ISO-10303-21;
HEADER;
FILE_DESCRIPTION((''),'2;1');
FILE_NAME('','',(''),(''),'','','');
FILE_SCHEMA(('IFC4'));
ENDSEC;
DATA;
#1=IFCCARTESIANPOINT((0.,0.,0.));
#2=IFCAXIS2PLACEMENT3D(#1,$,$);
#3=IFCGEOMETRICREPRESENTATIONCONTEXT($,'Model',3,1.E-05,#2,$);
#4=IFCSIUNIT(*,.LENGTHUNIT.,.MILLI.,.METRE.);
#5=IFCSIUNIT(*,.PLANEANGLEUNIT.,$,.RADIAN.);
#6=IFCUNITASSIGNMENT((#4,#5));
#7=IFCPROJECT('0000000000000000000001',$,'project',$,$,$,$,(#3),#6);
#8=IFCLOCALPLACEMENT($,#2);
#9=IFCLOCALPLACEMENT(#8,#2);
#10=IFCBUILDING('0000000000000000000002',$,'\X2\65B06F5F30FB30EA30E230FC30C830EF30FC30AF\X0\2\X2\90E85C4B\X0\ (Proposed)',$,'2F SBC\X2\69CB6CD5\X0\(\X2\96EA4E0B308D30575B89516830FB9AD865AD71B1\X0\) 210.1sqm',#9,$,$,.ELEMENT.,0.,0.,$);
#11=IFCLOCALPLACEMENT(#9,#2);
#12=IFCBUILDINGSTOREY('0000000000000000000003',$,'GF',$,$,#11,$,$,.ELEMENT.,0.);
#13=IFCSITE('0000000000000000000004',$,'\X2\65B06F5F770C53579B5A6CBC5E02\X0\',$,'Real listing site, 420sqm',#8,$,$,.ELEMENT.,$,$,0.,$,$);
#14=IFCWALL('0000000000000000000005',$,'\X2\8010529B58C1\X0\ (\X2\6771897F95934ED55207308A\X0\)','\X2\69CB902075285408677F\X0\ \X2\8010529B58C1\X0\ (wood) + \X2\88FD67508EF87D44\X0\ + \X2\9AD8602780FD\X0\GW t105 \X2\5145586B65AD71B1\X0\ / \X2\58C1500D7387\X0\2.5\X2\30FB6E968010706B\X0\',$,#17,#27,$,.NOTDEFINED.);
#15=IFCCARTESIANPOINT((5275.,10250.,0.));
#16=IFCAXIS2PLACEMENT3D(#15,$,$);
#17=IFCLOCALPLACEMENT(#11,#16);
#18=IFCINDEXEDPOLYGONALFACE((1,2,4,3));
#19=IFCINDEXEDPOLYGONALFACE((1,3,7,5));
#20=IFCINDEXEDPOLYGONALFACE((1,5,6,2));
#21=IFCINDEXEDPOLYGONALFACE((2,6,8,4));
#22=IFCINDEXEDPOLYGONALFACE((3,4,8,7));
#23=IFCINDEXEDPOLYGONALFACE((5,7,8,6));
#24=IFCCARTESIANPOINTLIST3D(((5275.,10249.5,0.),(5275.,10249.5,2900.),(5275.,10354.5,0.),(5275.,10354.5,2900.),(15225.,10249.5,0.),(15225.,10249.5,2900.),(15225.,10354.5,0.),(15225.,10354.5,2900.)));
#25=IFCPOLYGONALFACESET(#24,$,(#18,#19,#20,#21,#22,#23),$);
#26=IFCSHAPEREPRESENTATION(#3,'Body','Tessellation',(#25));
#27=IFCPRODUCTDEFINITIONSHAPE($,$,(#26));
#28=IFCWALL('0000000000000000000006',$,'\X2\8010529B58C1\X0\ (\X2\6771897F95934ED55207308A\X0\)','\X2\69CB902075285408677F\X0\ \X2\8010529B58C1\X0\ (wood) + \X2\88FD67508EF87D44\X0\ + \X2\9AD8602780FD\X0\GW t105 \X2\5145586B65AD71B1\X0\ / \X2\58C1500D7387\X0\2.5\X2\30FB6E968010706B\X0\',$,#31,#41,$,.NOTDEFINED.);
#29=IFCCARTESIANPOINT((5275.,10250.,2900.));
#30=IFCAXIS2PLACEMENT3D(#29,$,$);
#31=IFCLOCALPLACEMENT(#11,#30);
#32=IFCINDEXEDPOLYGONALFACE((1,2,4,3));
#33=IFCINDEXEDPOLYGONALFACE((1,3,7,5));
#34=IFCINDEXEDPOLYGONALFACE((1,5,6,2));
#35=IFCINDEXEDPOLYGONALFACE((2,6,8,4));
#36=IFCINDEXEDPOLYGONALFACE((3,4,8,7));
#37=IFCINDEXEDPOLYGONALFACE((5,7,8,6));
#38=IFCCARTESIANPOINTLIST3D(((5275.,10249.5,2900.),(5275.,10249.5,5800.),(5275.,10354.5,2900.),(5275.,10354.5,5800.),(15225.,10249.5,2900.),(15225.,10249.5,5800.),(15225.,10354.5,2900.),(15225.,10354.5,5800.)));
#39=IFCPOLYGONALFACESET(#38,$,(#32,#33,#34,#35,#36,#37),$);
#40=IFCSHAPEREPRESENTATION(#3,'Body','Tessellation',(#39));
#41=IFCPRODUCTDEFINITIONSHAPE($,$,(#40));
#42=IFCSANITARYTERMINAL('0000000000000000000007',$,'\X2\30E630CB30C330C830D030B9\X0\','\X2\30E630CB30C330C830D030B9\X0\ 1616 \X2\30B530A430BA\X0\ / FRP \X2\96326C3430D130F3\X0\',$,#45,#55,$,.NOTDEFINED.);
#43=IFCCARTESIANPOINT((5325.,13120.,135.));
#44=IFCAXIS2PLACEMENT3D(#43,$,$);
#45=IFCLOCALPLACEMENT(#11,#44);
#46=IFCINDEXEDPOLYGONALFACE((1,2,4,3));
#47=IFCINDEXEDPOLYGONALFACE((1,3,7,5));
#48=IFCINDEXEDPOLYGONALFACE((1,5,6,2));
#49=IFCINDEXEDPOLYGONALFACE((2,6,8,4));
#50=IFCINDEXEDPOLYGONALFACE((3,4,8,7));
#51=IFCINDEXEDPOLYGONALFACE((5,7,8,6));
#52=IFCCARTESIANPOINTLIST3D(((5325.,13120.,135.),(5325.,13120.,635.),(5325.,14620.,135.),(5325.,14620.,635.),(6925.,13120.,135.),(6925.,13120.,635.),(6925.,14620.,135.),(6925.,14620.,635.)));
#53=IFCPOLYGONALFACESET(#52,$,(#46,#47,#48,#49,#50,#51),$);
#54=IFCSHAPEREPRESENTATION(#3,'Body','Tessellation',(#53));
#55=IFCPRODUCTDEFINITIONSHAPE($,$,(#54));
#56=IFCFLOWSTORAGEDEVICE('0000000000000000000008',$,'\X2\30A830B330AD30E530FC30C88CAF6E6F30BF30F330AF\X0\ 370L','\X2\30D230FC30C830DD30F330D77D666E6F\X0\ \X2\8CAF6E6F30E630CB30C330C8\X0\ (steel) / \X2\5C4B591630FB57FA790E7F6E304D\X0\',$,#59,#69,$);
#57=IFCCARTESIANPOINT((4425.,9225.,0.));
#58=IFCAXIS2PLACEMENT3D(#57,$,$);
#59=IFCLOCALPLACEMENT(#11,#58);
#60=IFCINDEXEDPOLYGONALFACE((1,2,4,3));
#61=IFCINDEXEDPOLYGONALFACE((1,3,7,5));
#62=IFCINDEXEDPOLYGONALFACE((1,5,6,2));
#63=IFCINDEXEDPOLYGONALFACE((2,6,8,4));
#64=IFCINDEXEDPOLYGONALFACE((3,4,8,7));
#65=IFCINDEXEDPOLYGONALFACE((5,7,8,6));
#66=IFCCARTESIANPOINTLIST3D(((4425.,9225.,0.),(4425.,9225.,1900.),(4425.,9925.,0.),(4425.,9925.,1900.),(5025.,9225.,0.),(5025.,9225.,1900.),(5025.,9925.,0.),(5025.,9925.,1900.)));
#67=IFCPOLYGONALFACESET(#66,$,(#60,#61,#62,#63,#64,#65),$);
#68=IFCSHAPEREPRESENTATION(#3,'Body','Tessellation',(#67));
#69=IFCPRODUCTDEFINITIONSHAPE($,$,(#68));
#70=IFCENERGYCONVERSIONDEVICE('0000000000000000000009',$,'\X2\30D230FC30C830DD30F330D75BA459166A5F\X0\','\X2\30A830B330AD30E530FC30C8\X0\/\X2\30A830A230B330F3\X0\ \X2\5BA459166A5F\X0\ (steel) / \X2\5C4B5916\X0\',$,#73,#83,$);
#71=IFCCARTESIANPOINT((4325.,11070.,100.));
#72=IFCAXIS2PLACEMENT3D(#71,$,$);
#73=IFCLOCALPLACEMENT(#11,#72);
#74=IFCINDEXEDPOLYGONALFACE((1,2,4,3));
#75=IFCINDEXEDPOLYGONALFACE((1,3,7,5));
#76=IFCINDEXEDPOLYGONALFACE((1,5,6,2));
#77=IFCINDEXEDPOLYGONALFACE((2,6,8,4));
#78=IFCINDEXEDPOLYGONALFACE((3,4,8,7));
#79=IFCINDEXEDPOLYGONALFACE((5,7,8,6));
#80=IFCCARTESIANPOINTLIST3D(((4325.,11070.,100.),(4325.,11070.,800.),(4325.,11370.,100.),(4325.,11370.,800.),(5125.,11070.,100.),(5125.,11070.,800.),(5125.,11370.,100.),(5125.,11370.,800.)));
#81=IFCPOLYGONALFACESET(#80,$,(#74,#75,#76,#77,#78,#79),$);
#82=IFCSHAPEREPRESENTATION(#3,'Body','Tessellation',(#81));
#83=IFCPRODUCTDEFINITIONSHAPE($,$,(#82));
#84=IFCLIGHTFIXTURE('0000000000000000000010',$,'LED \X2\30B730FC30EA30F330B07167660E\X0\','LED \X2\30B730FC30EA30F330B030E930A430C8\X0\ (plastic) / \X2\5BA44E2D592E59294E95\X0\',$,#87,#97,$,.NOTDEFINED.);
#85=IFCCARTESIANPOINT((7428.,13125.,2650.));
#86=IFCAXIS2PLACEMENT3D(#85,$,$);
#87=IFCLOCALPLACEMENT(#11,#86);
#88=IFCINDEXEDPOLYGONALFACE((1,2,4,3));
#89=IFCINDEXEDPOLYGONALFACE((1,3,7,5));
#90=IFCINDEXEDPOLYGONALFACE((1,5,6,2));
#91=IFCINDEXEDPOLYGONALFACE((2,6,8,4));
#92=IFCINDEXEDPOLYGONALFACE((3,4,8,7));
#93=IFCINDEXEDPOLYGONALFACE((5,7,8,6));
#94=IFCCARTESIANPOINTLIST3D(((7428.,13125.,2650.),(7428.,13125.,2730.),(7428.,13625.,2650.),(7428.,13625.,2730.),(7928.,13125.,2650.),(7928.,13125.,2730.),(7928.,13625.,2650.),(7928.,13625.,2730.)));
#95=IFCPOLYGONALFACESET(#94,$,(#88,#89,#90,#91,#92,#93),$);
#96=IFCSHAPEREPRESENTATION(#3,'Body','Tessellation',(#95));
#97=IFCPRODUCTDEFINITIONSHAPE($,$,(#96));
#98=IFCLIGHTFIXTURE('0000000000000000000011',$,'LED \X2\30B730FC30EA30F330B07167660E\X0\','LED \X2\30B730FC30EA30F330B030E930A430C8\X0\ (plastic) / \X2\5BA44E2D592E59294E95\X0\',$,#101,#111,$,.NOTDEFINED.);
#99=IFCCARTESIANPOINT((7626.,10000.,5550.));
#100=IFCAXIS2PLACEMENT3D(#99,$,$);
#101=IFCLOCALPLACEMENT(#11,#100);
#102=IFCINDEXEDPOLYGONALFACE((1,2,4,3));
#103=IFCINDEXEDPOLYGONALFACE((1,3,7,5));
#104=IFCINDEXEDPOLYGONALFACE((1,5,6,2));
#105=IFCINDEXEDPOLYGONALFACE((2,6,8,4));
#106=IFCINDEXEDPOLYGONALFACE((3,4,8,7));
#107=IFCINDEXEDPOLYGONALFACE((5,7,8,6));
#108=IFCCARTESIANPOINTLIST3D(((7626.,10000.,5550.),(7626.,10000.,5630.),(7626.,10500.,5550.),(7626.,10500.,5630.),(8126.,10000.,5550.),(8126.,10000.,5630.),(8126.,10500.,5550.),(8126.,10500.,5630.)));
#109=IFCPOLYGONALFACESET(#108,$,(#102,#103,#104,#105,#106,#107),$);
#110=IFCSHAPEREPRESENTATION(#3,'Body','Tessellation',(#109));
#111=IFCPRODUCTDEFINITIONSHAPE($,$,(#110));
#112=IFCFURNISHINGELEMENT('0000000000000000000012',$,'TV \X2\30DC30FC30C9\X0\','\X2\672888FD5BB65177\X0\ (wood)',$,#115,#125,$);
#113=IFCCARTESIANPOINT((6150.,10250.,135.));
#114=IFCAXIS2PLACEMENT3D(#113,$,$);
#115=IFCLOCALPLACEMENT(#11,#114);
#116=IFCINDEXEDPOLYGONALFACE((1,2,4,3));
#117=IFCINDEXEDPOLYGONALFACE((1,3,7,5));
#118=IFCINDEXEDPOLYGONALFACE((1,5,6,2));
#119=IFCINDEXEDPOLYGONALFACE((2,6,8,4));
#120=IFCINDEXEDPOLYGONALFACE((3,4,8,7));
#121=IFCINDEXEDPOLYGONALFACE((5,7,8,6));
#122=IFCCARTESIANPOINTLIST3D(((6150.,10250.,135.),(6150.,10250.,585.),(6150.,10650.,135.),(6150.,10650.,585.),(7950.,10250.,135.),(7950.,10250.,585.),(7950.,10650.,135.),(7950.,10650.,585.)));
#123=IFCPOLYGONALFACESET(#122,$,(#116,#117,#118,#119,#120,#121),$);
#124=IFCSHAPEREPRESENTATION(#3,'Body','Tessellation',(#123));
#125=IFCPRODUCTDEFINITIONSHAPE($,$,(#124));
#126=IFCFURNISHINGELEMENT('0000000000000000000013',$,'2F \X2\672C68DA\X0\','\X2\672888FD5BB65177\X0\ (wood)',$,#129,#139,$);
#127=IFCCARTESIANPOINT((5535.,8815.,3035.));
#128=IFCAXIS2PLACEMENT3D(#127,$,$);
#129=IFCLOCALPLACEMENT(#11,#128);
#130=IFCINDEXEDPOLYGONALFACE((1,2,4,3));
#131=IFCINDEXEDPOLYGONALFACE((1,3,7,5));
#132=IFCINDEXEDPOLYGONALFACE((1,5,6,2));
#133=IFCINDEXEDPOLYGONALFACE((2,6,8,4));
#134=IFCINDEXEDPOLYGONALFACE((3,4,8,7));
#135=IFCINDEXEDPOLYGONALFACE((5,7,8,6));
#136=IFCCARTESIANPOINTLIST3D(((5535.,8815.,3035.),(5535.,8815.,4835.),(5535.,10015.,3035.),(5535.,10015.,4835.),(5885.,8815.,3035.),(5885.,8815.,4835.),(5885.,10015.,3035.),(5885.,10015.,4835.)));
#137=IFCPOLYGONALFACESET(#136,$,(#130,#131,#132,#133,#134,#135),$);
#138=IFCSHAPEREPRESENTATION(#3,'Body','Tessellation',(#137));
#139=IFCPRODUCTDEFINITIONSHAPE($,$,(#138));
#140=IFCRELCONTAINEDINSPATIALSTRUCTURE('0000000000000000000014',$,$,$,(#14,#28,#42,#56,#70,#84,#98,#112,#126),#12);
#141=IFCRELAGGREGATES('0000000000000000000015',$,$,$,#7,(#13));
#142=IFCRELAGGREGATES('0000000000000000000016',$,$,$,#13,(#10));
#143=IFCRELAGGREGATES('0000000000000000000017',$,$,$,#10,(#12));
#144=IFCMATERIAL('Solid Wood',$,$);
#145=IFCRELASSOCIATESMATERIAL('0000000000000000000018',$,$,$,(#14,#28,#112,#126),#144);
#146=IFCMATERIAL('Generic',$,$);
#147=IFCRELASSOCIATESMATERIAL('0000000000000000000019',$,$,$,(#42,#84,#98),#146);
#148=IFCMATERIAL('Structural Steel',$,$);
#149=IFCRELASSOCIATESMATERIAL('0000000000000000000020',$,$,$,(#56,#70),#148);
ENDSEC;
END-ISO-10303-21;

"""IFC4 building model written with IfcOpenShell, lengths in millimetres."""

from ifc_helpers import new_model, si_unit, frame, frame_2d, origin, place, context, project, spatial, rectangle, extrude, material, element, save


model = new_model("IFC4")

# Units and contexts
model_context = context("Model", 3, precision=1e-05, world=origin())
ifc_project = project(units=[si_unit("LENGTHUNIT", "METRE", prefix="MILLI"), si_unit("PLANEANGLEUNIT", "RADIAN")], contexts=[model_context])

# Site, building, storey
site_placement = place(None, origin())
site = spatial("IfcSite", under=ifc_project, at=site_placement, Name="新潟県南魚沼市", ObjectType="Real listing site, 420sqm", CompositionType="ELEMENT", RefElevation=0.0)
building_placement = place(site_placement, origin())
building = spatial("IfcBuilding", under=site, at=building_placement, Name="新潟・リモートワーク2部屋 (Proposed)", ObjectType="2F SBC構法(雪下ろし安全・高断熱) 210.1sqm", CompositionType="ELEMENT", ElevationOfRefHeight=0.0, ElevationOfTerrain=0.0)
storey_placement = place(building_placement, origin())
storey = spatial("IfcBuildingStorey", under=building, at=storey_placement, Name="GF", CompositionType="ELEMENT", Elevation=0.0)

# Shared definitions
ifc_material_1 = material(Name="Solid Wood")

# Wall
wall_1_placement = place(storey_placement, frame((5275.0, 10250.0, 0.0)))
element("IfcWall", 1, at=wall_1_placement, inside=storey, material=ifc_material_1, Name="耐力壁 (東西間仕切り)", Description="構造用合板 耐力壁 (wood) + 製材軸組 + 高性能GW t105 充填断熱 / 壁倍率2.5・準耐火", PredefinedType="NOTDEFINED", context=model_context, shape_type="SweptSolid", body=[
    extrude(rectangle(XDim=9950.0, YDim=105.0, at=frame_2d((4975.0, 52.0))), frame((5275.0, 10250.0, 0.0)), (0.0, 0.0, 1.0), 2900.0),
])

# Wall
wall_2_placement = place(storey_placement, frame((5275.0, 10250.0, 2900.0)))
element("IfcWall", 2, at=wall_2_placement, inside=storey, material=ifc_material_1, Name="耐力壁 (東西間仕切り)", Description="構造用合板 耐力壁 (wood) + 製材軸組 + 高性能GW t105 充填断熱 / 壁倍率2.5・準耐火", PredefinedType="NOTDEFINED", context=model_context, shape_type="SweptSolid", body=[
    extrude(rectangle(XDim=9950.0, YDim=105.0, at=frame_2d((4975.0, 52.0))), frame((5275.0, 10250.0, 2900.0)), (0.0, 0.0, 1.0), 2900.0),
])

# Sanitary terminal
ifc_material_2 = material(Name="Generic")
sanitary_terminal_placement = place(storey_placement, frame((5325.0, 13120.0, 135.0)))
element("IfcSanitaryTerminal", 3, at=sanitary_terminal_placement, inside=storey, material=ifc_material_2, Name="ユニットバス", Description="ユニットバス 1616 サイズ / FRP 防水パン", PredefinedType="NOTDEFINED", context=model_context, shape_type="SweptSolid", body=[
    extrude(rectangle(XDim=1600.0, YDim=1500.0, at=frame_2d((800.0, 750.0))), frame((5325.0, 13120.0, 135.0)), (0.0, 0.0, 1.0), 500.0),
])

# Flow storage device
ifc_material_3 = material(Name="Structural Steel")
flow_storage_device_placement = place(storey_placement, frame((4425.0, 9225.0, 0.0)))
element("IfcFlowStorageDevice", 4, at=flow_storage_device_placement, inside=storey, material=ifc_material_3, Name="エコキュート貯湯タンク 370L", Description="ヒートポンプ給湯 貯湯ユニット (steel) / 屋外・基礎置き", context=model_context, shape_type="SweptSolid", body=[
    extrude(rectangle(XDim=600.0, YDim=700.0, at=frame_2d((300.0, 350.0))), frame((4425.0, 9225.0, 0.0)), (0.0, 0.0, 1.0), 1900.0),
])

# Energy conversion device
energy_conversion_device_placement = place(storey_placement, frame((4325.0, 11070.0, 100.0)))
element("IfcEnergyConversionDevice", 5, at=energy_conversion_device_placement, inside=storey, material=ifc_material_3, Name="ヒートポンプ室外機", Description="エコキュート/エアコン 室外機 (steel) / 屋外", context=model_context, shape_type="SweptSolid", body=[
    extrude(rectangle(XDim=800.0, YDim=300.0, at=frame_2d((400.0, 150.0))), frame((4325.0, 11070.0, 100.0)), (0.0, 0.0, 1.0), 700.0),
])

# Light fixtures
light_fixture_1_placement = place(storey_placement, frame((7428.0, 13125.0, 2650.0)))
element("IfcLightFixture", 6, at=light_fixture_1_placement, inside=storey, material=ifc_material_2, Name="LED シーリング照明", Description="LED シーリングライト (plastic) / 室中央天井", PredefinedType="NOTDEFINED", context=model_context, shape_type="SweptSolid", body=[
    extrude(rectangle(XDim=500.0, YDim=500.0, at=frame_2d((250.0, 250.0))), frame((7428.0, 13125.0, 2650.0)), (0.0, 0.0, 1.0), 80.0),
])
light_fixture_2_placement = place(storey_placement, frame((7626.0, 10000.0, 5550.0)))
element("IfcLightFixture", 7, at=light_fixture_2_placement, inside=storey, material=ifc_material_2, Name="LED シーリング照明", Description="LED シーリングライト (plastic) / 室中央天井", PredefinedType="NOTDEFINED", context=model_context, shape_type="SweptSolid", body=[
    extrude(rectangle(XDim=500.0, YDim=500.0, at=frame_2d((250.0, 250.0))), frame((7626.0, 10000.0, 5550.0)), (0.0, 0.0, 1.0), 80.0),
])

# Furnishing elements
furnishing_1_placement = place(storey_placement, frame((6150.0, 10250.0, 135.0)))
element("IfcFurnishingElement", 8, at=furnishing_1_placement, inside=storey, material=ifc_material_1, Name="TV ボード", Description="木製家具 (wood)", context=model_context, shape_type="SweptSolid", body=[
    extrude(rectangle(XDim=1800.0, YDim=400.0, at=frame_2d((900.0, 200.0))), frame((6150.0, 10250.0, 135.0)), (0.0, 0.0, 1.0), 450.0),
])
furnishing_2_placement = place(storey_placement, frame((5535.0, 8815.0, 3035.0)))
element("IfcFurnishingElement", 9, at=furnishing_2_placement, inside=storey, material=ifc_material_1, Name="2F 本棚", Description="木製家具 (wood)", context=model_context, shape_type="SweptSolid", body=[
    extrude(rectangle(XDim=350.0, YDim=1200.0, at=frame_2d((175.0, 600.0))), frame((5535.0, 8815.0, 3035.0)), (0.0, 0.0, 1.0), 1800.0),
])

save(model, "model.ifc")
